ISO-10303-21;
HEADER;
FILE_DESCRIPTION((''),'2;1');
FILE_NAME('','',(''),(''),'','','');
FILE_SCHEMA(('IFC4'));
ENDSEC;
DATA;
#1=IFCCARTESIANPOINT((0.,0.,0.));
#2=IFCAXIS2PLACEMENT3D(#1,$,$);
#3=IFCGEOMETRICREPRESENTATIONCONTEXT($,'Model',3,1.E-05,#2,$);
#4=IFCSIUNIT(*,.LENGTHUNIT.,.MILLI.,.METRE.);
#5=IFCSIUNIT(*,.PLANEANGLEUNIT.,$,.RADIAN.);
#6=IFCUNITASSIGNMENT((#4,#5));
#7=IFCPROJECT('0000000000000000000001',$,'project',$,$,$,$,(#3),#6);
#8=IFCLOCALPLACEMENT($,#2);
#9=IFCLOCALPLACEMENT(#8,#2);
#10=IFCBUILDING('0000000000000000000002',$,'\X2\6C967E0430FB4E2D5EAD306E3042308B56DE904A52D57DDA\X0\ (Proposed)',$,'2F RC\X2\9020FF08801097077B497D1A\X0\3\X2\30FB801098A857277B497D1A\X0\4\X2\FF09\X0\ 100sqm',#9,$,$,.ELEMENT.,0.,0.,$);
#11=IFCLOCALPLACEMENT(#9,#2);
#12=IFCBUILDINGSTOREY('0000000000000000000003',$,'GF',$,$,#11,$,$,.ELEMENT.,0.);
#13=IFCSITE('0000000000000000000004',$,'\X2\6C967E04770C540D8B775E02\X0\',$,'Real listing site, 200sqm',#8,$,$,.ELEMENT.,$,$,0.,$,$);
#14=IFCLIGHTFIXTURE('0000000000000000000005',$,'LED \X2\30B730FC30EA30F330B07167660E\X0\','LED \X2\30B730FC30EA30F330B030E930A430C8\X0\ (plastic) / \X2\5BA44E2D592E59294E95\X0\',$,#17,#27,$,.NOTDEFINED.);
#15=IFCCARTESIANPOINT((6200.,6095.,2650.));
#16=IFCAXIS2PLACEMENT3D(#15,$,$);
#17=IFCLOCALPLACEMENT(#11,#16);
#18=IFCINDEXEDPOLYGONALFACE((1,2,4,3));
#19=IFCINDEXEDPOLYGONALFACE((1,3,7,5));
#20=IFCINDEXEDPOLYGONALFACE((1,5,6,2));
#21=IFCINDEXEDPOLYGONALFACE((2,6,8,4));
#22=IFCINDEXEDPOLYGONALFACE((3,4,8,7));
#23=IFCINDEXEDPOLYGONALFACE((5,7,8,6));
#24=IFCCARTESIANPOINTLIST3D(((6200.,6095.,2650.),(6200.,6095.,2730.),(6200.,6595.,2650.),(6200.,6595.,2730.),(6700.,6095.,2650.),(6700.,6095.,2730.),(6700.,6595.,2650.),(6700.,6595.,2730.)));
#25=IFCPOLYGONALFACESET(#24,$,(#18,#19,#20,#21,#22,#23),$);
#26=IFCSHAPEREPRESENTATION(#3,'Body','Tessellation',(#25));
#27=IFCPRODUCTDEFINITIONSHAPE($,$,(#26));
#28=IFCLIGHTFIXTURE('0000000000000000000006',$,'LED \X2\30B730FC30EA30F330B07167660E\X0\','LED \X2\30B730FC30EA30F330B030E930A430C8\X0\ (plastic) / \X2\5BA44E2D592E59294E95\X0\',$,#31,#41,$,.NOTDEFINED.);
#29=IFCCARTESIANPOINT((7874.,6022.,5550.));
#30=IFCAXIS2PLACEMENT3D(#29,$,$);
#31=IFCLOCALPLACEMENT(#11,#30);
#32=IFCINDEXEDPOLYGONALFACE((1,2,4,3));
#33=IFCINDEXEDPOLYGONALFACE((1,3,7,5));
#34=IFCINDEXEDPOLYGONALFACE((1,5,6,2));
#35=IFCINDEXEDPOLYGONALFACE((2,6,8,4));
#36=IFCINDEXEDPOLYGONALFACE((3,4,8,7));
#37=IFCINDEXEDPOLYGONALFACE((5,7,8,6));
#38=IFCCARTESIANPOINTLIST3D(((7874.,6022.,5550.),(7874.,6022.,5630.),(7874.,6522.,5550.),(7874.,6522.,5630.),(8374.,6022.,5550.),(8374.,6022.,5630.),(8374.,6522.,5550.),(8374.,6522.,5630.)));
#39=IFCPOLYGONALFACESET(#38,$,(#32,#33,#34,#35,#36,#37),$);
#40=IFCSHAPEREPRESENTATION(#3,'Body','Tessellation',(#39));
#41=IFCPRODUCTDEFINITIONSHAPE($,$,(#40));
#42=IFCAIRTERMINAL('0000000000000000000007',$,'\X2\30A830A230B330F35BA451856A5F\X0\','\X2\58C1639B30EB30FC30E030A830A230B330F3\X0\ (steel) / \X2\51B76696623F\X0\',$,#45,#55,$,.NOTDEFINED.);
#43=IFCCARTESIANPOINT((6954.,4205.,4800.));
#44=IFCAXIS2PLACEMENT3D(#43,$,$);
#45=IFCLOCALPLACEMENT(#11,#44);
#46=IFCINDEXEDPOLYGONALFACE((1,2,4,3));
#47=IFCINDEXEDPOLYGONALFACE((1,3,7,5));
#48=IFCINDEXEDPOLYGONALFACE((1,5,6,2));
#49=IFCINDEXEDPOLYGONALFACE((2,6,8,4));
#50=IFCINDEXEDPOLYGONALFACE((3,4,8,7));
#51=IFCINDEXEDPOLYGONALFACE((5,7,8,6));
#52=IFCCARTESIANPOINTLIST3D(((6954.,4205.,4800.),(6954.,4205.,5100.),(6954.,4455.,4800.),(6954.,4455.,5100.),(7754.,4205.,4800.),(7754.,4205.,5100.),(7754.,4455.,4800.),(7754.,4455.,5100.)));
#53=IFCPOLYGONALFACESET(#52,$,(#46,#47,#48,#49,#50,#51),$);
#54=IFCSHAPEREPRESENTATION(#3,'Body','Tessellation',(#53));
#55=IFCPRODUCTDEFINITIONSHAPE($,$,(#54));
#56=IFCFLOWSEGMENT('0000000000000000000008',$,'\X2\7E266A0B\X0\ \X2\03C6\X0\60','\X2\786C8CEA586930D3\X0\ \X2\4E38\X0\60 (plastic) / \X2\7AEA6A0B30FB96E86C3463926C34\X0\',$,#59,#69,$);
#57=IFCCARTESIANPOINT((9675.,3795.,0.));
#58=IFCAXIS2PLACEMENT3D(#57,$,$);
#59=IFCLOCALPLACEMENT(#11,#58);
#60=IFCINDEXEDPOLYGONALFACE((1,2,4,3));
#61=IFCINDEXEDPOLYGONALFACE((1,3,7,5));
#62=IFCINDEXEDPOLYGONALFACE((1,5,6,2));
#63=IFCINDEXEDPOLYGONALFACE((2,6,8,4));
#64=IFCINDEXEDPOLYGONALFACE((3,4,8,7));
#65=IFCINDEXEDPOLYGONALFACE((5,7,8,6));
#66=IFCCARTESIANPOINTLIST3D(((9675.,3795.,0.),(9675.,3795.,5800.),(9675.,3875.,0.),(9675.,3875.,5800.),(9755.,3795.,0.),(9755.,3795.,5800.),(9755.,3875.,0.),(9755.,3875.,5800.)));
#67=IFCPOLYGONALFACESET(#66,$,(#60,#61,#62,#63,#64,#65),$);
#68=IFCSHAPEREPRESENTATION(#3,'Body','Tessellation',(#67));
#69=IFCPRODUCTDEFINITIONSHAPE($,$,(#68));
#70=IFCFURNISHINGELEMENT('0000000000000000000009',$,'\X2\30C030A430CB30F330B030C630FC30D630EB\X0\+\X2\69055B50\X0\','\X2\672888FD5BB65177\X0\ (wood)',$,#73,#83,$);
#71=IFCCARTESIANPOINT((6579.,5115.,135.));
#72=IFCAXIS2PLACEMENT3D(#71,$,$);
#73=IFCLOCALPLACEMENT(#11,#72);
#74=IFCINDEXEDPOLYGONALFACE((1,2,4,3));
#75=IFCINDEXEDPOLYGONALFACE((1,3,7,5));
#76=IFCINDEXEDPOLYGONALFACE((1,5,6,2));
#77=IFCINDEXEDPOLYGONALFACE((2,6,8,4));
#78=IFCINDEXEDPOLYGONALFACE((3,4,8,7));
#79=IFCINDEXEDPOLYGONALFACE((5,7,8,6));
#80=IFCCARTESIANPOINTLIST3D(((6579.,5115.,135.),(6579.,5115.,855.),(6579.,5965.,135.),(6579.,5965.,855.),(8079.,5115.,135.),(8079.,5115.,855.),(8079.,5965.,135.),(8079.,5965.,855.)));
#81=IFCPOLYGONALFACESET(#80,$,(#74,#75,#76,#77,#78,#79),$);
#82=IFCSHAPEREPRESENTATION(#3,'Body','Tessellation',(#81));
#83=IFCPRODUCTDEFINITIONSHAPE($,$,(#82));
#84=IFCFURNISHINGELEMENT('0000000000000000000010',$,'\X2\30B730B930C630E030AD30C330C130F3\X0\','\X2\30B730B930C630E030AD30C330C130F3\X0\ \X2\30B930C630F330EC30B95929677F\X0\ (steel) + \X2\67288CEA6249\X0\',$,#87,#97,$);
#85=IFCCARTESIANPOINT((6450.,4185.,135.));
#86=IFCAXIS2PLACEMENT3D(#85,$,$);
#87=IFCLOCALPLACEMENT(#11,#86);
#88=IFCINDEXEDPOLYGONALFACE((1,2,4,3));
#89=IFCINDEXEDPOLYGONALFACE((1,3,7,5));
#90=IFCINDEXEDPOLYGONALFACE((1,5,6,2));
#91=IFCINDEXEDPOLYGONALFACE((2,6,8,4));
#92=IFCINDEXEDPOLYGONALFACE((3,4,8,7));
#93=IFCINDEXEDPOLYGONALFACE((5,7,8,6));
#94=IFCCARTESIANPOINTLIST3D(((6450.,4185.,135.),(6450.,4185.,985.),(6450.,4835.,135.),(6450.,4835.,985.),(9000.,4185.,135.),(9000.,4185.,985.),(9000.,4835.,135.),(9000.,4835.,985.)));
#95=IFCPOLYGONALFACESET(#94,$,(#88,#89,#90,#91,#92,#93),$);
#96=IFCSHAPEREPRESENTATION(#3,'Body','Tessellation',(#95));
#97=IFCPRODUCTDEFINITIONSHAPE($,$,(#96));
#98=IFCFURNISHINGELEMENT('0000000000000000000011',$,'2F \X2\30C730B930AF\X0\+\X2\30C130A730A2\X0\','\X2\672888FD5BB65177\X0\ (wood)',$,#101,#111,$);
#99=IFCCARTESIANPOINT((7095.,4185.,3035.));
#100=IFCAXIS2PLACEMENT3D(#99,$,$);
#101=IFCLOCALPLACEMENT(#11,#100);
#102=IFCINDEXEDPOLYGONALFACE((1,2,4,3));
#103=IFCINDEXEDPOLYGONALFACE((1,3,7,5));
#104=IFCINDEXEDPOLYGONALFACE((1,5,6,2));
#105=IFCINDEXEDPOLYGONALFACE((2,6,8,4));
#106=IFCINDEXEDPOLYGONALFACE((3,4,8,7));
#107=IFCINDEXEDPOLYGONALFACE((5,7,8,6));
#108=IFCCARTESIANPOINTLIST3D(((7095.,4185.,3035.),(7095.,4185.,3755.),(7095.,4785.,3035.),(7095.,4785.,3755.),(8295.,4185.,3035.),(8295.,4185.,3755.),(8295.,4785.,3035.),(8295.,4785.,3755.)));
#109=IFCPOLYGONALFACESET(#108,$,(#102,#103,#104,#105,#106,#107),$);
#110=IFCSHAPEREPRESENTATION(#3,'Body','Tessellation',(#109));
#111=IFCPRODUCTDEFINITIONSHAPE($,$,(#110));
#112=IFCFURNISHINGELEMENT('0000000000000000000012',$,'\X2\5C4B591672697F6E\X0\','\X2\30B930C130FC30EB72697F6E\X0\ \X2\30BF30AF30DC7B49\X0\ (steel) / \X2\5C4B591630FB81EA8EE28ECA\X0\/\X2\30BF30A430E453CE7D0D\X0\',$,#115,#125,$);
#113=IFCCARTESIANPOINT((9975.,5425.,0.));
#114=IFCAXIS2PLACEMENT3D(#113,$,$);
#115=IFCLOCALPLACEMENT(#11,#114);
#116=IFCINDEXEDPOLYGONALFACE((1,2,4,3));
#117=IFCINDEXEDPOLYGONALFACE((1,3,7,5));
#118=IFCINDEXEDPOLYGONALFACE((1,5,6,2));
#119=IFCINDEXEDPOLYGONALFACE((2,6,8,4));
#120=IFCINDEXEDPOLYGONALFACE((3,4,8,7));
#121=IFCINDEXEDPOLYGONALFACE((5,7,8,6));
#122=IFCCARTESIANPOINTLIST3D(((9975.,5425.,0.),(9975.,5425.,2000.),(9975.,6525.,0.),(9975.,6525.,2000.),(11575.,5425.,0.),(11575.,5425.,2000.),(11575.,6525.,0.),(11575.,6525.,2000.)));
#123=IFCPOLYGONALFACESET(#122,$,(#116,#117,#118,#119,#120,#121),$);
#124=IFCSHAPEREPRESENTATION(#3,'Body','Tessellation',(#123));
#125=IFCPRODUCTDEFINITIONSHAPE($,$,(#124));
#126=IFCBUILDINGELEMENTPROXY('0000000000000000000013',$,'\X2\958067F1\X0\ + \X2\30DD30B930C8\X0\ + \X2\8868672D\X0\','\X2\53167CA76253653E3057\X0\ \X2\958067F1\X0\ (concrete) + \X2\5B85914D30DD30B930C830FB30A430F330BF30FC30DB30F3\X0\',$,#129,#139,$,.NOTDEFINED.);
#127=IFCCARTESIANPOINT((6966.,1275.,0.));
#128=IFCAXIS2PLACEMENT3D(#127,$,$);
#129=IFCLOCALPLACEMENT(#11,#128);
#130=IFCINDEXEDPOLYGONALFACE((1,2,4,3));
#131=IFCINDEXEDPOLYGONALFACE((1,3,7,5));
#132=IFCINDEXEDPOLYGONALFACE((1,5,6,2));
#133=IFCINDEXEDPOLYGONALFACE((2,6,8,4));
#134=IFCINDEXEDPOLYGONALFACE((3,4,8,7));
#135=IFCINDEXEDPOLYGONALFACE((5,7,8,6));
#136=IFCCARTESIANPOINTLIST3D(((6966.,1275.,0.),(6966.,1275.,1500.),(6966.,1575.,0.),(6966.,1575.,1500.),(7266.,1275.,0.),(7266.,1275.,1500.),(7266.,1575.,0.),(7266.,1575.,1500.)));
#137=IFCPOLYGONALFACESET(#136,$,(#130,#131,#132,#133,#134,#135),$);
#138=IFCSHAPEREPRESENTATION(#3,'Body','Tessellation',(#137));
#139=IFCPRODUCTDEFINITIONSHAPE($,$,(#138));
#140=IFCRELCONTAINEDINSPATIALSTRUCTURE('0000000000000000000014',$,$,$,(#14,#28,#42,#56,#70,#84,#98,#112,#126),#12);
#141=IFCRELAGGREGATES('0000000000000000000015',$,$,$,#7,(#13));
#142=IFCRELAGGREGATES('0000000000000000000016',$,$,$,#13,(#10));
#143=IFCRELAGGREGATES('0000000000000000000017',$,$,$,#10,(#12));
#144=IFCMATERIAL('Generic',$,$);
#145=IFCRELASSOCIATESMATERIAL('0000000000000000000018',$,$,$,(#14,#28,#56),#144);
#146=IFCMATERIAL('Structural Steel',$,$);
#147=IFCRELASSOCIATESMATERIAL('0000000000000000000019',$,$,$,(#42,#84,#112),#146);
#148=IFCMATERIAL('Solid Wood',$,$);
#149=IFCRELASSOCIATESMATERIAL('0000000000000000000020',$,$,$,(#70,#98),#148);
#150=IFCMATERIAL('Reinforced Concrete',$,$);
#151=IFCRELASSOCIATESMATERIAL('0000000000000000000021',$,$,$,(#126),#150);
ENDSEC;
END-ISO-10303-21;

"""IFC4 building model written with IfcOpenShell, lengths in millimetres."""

from ifc_helpers import new_model, si_unit, frame, frame_2d, origin, place, context, project, spatial, rectangle, extrude, material, element, save


model = new_model("IFC4")

# Units and contexts
model_context = context("Model", 3, precision=1e-05, world=origin())
ifc_project = project(units=[si_unit("LENGTHUNIT", "METRE", prefix="MILLI"), si_unit("PLANEANGLEUNIT", "RADIAN")], contexts=[model_context])

# Site, building, storey
site_placement = place(None, origin())
site = spatial("IfcSite", under=ifc_project, at=site_placement, Name="沖縄県名護市", ObjectType="Real listing site, 200sqm", CompositionType="ELEMENT", RefElevation=0.0)
building_placement = place(site_placement, origin())
building = spatial("IfcBuilding", under=site, at=building_placement, Name="沖縄・中庭のある回遊動線 (Proposed)", ObjectType="2F RC造（耐震等級3・耐風圧等級4） 100sqm", CompositionType="ELEMENT", ElevationOfRefHeight=0.0, ElevationOfTerrain=0.0)
storey_placement = place(building_placement, origin())
storey = spatial("IfcBuildingStorey", under=building, at=storey_placement, Name="GF", CompositionType="ELEMENT", Elevation=0.0)

# Shared definitions
ifc_material_1 = material(Name="Solid Wood")

# Shared definitions
ifc_material_2 = material(Name="Reinforced Concrete")

# Shared definitions
ifc_material_3 = material(Name="Structural Steel")

# Shared definitions
ifc_material_4 = material(Name="Generic")

# Light fixtures
light_fixture_1_placement = place(storey_placement, frame((6200.0, 6095.0, 2650.0)))
element("IfcLightFixture", 1, at=light_fixture_1_placement, inside=storey, material=ifc_material_4, Name="LED シーリング照明", Description="LED シーリングライト (plastic) / 室中央天井", PredefinedType="NOTDEFINED", context=model_context, shape_type="SweptSolid", body=[
    extrude(rectangle(XDim=500.0, YDim=500.0, at=frame_2d((250.0, 250.0))), frame((6200.0, 6095.0, 2650.0)), (0.0, 0.0, 1.0), 80.0),
])
light_fixture_2_placement = place(storey_placement, frame((7874.0, 6022.0, 5550.0)))
element("IfcLightFixture", 2, at=light_fixture_2_placement, inside=storey, material=ifc_material_4, Name="LED シーリング照明", Description="LED シーリングライト (plastic) / 室中央天井", PredefinedType="NOTDEFINED", context=model_context, shape_type="SweptSolid", body=[
    extrude(rectangle(XDim=500.0, YDim=500.0, at=frame_2d((250.0, 250.0))), frame((7874.0, 6022.0, 5550.0)), (0.0, 0.0, 1.0), 80.0),
])

# Air terminal
air_terminal_placement = place(storey_placement, frame((6954.0, 4205.0, 4800.0)))
element("IfcAirTerminal", 3, at=air_terminal_placement, inside=storey, material=ifc_material_3, Name="エアコン室内機", Description="壁掛ルームエアコン (steel) / 冷暖房", PredefinedType="NOTDEFINED", context=model_context, shape_type="SweptSolid", body=[
    extrude(rectangle(XDim=800.0, YDim=250.0, at=frame_2d((400.0, 125.0))), frame((6954.0, 4205.0, 4800.0)), (0.0, 0.0, 1.0), 300.0),
])

# Flow segment
flow_segment_placement = place(storey_placement, frame((9675.0, 3795.0, 0.0)))
element("IfcFlowSegment", 4, at=flow_segment_placement, inside=storey, material=ifc_material_4, Name="縦樋 φ60", Description="硬質塩ビ 丸60 (plastic) / 竪樋・雨水排水", context=model_context, shape_type="SweptSolid", body=[
    extrude(rectangle(XDim=80.0, YDim=80.0, at=frame_2d((40.0, 40.0))), frame((9675.0, 3795.0, 0.0)), (0.0, 0.0, 1.0), 5800.0),
])

# Furnishing elements
furnishing_1_placement = place(storey_placement, frame((6579.0, 5115.0, 135.0)))
element("IfcFurnishingElement", 5, at=furnishing_1_placement, inside=storey, material=ifc_material_1, Name="ダイニングテーブル+椅子", Description="木製家具 (wood)", context=model_context, shape_type="SweptSolid", body=[
    extrude(rectangle(XDim=1500.0, YDim=850.0, at=frame_2d((750.0, 425.0))), frame((6579.0, 5115.0, 135.0)), (0.0, 0.0, 1.0), 720.0),
])
furnishing_2_placement = place(storey_placement, frame((6450.0, 4185.0, 135.0)))
element("IfcFurnishingElement", 6, at=furnishing_2_placement, inside=storey, material=ifc_material_3, Name="システムキッチン", Description="システムキッチン ステンレス天板 (steel) + 木質扉", context=model_context, shape_type="SweptSolid", body=[
    extrude(rectangle(XDim=2550.0, YDim=650.0, at=frame_2d((1275.0, 325.0))), frame((6450.0, 4185.0, 135.0)), (0.0, 0.0, 1.0), 850.0),
])
furnishing_3_placement = place(storey_placement, frame((7095.0, 4185.0, 3035.0)))
element("IfcFurnishingElement", 7, at=furnishing_3_placement, inside=storey, material=ifc_material_1, Name="2F デスク+チェア", Description="木製家具 (wood)", context=model_context, shape_type="SweptSolid", body=[
    extrude(rectangle(XDim=1200.0, YDim=600.0, at=frame_2d((600.0, 300.0))), frame((7095.0, 4185.0, 3035.0)), (0.0, 0.0, 1.0), 720.0),
])
furnishing_4_placement = place(storey_placement, frame((9975.0, 5425.0, 0.0)))
element("IfcFurnishingElement", 8, at=furnishing_4_placement, inside=storey, material=ifc_material_3, Name="屋外物置", Description="スチール物置 タクボ等 (steel) / 屋外・自転車/タイヤ収納", context=model_context, shape_type="SweptSolid", body=[
    extrude(rectangle(XDim=1600.0, YDim=1100.0, at=frame_2d((800.0, 550.0))), frame((9975.0, 5425.0, 0.0)), (0.0, 0.0, 1.0), 2000.0),
])

# Building element proxy
proxy_placement = place(storey_placement, frame((6966.0, 1275.0, 0.0)))
element("IfcBuildingElementProxy", 9, at=proxy_placement, inside=storey, material=ifc_material_2, Name="門柱 + ポスト + 表札", Description="化粧打放し 門柱 (concrete) + 宅配ポスト・インターホン", PredefinedType="NOTDEFINED", context=model_context, shape_type="SweptSolid", body=[
    extrude(rectangle(XDim=300.0, YDim=300.0, at=frame_2d((150.0, 150.0))), frame((6966.0, 1275.0, 0.0)), (0.0, 0.0, 1.0), 1500.0),
])

save(model, "model.ifc")
